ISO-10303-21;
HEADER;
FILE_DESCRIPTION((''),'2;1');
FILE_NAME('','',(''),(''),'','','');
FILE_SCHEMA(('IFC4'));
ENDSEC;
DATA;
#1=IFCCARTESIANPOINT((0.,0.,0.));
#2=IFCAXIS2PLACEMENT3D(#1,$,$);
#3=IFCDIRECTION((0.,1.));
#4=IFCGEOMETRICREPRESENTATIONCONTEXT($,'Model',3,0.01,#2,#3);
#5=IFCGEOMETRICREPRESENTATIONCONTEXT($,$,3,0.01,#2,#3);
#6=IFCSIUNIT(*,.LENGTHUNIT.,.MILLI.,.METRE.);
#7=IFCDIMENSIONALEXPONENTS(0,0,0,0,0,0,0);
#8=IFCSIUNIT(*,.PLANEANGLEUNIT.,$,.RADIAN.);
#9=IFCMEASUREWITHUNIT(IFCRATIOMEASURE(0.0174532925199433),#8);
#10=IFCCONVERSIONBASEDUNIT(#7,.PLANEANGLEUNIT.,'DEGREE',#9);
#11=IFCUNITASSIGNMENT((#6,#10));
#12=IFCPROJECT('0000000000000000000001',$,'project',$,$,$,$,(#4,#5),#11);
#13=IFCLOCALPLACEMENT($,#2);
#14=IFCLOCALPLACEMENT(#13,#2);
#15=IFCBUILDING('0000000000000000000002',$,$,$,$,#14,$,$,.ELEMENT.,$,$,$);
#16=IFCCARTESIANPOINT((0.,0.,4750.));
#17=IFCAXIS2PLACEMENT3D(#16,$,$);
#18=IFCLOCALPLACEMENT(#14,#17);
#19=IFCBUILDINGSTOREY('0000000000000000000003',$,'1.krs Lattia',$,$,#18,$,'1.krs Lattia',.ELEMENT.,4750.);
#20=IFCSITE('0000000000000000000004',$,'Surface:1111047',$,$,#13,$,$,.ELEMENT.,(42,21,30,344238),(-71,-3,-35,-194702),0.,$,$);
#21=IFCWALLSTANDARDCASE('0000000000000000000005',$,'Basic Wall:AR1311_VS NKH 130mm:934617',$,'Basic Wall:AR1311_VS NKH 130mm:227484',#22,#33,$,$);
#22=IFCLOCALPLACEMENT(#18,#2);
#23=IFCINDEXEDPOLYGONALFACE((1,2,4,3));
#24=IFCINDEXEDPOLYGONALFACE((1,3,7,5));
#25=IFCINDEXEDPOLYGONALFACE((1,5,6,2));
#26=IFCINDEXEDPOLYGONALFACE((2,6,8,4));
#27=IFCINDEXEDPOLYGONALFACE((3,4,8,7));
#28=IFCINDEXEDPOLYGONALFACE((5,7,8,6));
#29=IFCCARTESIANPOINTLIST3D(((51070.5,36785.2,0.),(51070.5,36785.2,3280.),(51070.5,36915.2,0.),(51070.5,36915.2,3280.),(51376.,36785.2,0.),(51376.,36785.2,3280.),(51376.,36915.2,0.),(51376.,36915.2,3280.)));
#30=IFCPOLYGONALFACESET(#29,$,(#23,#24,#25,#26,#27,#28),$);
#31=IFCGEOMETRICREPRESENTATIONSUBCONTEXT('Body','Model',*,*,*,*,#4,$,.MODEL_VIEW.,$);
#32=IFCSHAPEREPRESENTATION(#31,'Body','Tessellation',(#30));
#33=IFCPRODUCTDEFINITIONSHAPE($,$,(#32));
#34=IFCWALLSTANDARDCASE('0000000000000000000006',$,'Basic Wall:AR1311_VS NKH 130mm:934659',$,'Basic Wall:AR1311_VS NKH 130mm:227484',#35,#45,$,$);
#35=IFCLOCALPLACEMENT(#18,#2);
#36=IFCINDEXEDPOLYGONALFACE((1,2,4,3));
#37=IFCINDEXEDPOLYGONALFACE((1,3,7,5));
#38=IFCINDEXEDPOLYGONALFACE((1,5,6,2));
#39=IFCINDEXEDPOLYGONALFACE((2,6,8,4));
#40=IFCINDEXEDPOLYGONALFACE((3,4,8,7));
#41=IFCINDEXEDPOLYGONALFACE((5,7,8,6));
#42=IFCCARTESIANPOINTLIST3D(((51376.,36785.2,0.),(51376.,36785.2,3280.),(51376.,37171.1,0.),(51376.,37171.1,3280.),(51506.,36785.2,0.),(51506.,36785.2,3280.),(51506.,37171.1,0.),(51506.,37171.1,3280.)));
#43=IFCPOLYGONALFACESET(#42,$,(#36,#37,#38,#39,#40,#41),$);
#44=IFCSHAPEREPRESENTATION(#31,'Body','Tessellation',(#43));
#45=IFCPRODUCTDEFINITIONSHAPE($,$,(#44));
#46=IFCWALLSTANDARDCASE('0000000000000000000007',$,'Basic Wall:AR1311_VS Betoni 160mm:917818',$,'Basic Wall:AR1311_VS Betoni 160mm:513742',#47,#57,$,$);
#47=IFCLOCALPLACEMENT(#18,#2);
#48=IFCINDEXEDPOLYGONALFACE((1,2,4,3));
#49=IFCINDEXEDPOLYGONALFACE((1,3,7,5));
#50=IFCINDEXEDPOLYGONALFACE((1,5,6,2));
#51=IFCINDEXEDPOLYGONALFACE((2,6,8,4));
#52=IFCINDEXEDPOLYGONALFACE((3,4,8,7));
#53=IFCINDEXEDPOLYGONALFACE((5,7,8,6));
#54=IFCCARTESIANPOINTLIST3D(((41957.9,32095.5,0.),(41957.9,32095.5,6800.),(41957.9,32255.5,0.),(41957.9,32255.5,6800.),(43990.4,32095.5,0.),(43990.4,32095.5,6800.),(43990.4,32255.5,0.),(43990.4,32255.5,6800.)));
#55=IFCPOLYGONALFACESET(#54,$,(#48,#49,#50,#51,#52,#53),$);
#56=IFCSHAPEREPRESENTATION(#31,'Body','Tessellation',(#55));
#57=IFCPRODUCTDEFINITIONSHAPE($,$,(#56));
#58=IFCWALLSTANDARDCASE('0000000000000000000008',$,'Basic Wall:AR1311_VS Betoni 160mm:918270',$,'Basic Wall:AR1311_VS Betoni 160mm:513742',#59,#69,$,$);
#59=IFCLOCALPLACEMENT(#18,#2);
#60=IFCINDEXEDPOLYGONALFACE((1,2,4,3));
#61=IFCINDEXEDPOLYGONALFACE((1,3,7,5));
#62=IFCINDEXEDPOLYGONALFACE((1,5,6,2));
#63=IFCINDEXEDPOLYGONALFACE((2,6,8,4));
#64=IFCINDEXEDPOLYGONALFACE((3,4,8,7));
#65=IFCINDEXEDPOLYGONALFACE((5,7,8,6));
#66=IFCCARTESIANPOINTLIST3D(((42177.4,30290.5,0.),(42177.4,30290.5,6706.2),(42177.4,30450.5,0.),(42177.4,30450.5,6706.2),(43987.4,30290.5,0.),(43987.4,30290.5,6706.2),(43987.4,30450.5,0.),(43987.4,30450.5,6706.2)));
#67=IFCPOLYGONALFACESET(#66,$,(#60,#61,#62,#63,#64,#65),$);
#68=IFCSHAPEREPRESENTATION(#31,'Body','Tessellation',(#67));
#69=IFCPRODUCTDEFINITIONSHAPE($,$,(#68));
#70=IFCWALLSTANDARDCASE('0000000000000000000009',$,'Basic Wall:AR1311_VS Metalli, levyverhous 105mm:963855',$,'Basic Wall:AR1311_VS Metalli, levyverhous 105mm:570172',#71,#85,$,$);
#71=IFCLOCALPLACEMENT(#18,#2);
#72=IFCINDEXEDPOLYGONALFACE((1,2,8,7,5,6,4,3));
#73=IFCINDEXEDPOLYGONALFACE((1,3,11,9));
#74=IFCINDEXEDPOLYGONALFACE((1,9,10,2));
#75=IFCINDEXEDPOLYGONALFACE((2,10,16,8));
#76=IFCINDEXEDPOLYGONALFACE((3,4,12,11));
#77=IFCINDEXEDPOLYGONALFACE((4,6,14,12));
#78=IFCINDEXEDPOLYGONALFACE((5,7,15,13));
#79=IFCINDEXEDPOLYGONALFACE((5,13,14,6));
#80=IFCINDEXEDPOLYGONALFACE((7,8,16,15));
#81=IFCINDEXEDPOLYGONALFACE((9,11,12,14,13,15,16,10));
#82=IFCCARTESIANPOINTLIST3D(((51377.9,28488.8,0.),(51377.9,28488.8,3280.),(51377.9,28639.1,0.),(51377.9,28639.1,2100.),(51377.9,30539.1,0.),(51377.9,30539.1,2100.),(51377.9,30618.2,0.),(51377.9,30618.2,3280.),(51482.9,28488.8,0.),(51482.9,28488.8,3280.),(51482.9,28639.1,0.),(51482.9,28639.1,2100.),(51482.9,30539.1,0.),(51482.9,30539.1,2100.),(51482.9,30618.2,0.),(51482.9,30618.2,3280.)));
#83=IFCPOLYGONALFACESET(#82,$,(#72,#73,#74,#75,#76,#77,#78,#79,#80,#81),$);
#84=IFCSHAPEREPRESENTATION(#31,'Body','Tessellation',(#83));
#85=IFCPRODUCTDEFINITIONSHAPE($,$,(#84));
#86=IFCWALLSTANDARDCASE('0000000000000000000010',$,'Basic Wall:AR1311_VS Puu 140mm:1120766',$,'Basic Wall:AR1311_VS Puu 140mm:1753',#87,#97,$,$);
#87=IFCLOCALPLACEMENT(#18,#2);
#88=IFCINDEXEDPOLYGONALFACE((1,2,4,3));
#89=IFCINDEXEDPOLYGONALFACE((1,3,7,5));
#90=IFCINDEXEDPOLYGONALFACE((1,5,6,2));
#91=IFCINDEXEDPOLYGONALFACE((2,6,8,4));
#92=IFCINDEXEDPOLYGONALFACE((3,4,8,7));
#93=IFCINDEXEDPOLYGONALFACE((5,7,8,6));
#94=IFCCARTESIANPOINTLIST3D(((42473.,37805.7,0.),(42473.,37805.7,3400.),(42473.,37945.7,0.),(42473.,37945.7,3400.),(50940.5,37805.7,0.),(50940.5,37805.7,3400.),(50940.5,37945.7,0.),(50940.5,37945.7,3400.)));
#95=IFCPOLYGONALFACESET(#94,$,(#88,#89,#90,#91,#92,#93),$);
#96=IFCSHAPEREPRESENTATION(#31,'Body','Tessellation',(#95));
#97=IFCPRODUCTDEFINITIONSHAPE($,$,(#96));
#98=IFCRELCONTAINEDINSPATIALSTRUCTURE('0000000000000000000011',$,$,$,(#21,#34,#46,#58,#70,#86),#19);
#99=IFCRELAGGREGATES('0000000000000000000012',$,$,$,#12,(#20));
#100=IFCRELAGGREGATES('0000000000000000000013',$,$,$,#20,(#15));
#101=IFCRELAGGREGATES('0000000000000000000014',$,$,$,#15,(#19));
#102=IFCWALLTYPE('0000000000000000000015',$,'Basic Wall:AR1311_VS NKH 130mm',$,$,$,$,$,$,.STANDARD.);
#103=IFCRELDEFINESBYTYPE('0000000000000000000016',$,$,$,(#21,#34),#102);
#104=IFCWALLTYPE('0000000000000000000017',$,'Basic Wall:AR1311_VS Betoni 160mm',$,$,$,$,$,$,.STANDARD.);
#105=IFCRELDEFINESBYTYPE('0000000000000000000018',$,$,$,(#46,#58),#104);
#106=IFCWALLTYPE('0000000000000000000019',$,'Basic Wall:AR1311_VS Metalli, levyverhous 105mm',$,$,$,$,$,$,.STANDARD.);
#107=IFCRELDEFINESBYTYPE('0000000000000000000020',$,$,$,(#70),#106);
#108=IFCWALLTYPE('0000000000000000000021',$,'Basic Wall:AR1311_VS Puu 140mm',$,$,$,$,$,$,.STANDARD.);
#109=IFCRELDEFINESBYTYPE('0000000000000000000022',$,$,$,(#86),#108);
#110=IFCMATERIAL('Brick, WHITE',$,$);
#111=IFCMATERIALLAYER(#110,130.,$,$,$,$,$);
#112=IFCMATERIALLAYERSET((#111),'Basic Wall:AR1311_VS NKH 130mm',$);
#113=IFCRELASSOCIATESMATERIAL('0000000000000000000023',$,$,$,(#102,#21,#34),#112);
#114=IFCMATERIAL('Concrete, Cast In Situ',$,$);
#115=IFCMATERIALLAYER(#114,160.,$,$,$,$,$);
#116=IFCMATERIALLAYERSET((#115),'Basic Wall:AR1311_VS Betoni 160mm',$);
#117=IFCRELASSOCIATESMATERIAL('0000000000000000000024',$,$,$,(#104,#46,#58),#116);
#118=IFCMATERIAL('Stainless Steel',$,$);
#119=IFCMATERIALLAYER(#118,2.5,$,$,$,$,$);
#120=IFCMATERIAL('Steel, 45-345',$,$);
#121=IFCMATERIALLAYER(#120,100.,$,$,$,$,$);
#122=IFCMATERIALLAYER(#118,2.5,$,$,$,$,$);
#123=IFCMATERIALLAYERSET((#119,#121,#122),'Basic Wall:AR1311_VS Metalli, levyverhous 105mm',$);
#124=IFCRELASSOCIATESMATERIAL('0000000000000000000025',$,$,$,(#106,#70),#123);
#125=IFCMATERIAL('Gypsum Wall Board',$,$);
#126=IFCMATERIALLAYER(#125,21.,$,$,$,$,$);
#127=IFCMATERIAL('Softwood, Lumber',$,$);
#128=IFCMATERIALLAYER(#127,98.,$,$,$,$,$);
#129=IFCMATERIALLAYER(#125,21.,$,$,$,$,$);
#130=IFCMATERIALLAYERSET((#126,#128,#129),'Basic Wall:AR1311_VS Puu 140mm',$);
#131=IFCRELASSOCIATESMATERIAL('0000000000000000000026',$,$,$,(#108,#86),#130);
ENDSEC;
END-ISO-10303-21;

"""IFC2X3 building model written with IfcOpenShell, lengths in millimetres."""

from ifc_helpers import new_model, entity, si_unit, converted_unit, direction, frame, frame_2d, origin, place, context, subcontext, project, spatial, polyline, rectangle, extrude, clip, bounded_halfspace, material, layer, layer_set, layer_usage, type_object, element, save


model = new_model("IFC2X3")

# Units and contexts
model_context = context("Model", 3, precision=0.01, world=origin(), true_north=direction((0.0, 1.0)))
context_of_model = context(None, 3, precision=0.01, world=origin(), true_north=direction((0.0, 1.0)))
body_context = subcontext(model_context, "Body", "Model", "MODEL_VIEW")
ifc_project = project(units=[si_unit("LENGTHUNIT", "METRE", prefix="MILLI"), converted_unit("PLANEANGLEUNIT", "DEGREE", entity("IfcRatioMeasure", 0.0174532925199433), si_unit("PLANEANGLEUNIT", "RADIAN"), dimensions=[0, 0, 0, 0, 0, 0, 0])], contexts=[model_context, context_of_model])

# Site, building, storey
site_placement = place(None, origin())
site = spatial("IfcSite", under=ifc_project, at=site_placement, Name="Surface:1111047", CompositionType="ELEMENT", RefLatitude=(42, 21, 30, 344238), RefLongitude=(-71, -3, -35, -194702), RefElevation=0.0)
building_placement = place(site_placement, origin())
building = spatial("IfcBuilding", under=site, at=building_placement, CompositionType="ELEMENT")
storey_placement = place(building_placement, frame((0.0, 0.0, 4750.0)))
storey = spatial("IfcBuildingStorey", under=building, at=storey_placement, Name="1.krs Lattia", LongName="1.krs Lattia", CompositionType="ELEMENT", Elevation=4750.0)

# Walls
ifc_material_1 = material(Name="Brick, WHITE")
ifc_layer_1 = layer(ifc_material_1, 130.0)
ifc_layer_set_1 = layer_set([ifc_layer_1], Name="Basic Wall:AR1311_VS NKH 130mm")
wall_type_1 = type_object("IfcWallType", Name="Basic Wall:AR1311_VS NKH 130mm", PredefinedType="STANDARD", material=ifc_layer_set_1)
ifc_layer_usage_1 = layer_usage(ifc_layer_set_1, "AXIS2", "NEGATIVE", 65.0)
wall_1_placement = place(storey_placement, frame((51070.5, 36850.2, 0.0)))
element("IfcWallStandardCase", 1, at=wall_1_placement, inside=storey, type_object=wall_type_1, material=ifc_layer_usage_1, Name="Basic Wall:AR1311_VS NKH 130mm:934617", ObjectType="Basic Wall:AR1311_VS NKH 130mm:227484", context=body_context, shape_type="Clipping", body=[
    clip(extrude(rectangle(XDim=305.5, YDim=130.0, at=frame_2d((152.8, 0.0), x_axis=(-1.0, 0.0))), origin(), (0.0, 0.0, 1.0), 3280.0), bounded_halfspace(frame((0.0, -65.0, 3280.0), z_axis=(0.0, 0.0, -1.0), x_axis=(-1.0, 0.0, 0.0)), True, frame((0.0, -65.0, 3280.0)), polyline([(0.0, 0.0), (305.5, 0.0), (305.5, 130.0), (0.0, 130.0), (0.0, 0.0)]))),
])
ifc_layer_usage_2 = layer_usage(ifc_layer_set_1, "AXIS2", "NEGATIVE", 65.0)
wall_2_placement = place(storey_placement, frame((51441.0, 36785.2, 0.0), z_axis=(0.0, 0.0, 1.0), x_axis=(0.0, 1.0, 0.0)))
element("IfcWallStandardCase", 2, at=wall_2_placement, inside=storey, type_object=wall_type_1, material=ifc_layer_usage_2, Name="Basic Wall:AR1311_VS NKH 130mm:934659", ObjectType="Basic Wall:AR1311_VS NKH 130mm:227484", context=body_context, shape_type="Clipping", body=[
    clip(extrude(rectangle(XDim=385.9, YDim=130.0, at=frame_2d((193.0, 0.0), x_axis=(-1.0, 0.0))), origin(), (0.0, 0.0, 1.0), 3280.0), bounded_halfspace(frame((0.0, -65.0, 3280.0), z_axis=(0.0, 0.0, -1.0), x_axis=(0.0, 1.0, 0.0)), True, frame((0.0, -65.0, 3280.0)), polyline([(0.0, 0.0), (255.9, 0.0), (385.9, 0.0), (385.9, 130.0), (130.0, 130.0), (0.0, 130.0), (0.0, 0.0)]))),
])
ifc_material_2 = material(Name="Concrete, Cast In Situ")
ifc_layer_2 = layer(ifc_material_2, 160.0)
ifc_layer_set_2 = layer_set([ifc_layer_2], Name="Basic Wall:AR1311_VS Betoni 160mm")
ifc_layer_usage_3 = layer_usage(ifc_layer_set_2, "AXIS2", "NEGATIVE", 80.0)
wall_type_2 = type_object("IfcWallType", Name="Basic Wall:AR1311_VS Betoni 160mm", PredefinedType="STANDARD", material=ifc_layer_set_2)
wall_3_placement = place(storey_placement, frame((43990.4, 32175.5, 0.0), z_axis=(0.0, 0.0, 1.0), x_axis=(-1.0, 0.0, 0.0)))
element("IfcWallStandardCase", 3, at=wall_3_placement, inside=storey, type_object=wall_type_2, material=ifc_layer_usage_3, Name="Basic Wall:AR1311_VS Betoni 160mm:917818", ObjectType="Basic Wall:AR1311_VS Betoni 160mm:513742", context=body_context, shape_type="SweptSolid", body=[
    extrude(rectangle(XDim=2032.5, YDim=160.0, at=frame_2d((1016.2, 0.0), x_axis=(-1.0, 0.0))), origin(), (0.0, 0.0, 1.0), 6800.0),
])
ifc_layer_usage_4 = layer_usage(ifc_layer_set_2, "AXIS2", "NEGATIVE", 80.0)
wall_4_placement = place(storey_placement, frame((42177.4, 30370.5, 0.0)))
element("IfcWallStandardCase", 4, at=wall_4_placement, inside=storey, type_object=wall_type_2, material=ifc_layer_usage_4, Name="Basic Wall:AR1311_VS Betoni 160mm:918270", ObjectType="Basic Wall:AR1311_VS Betoni 160mm:513742", context=body_context, shape_type="SweptSolid", body=[
    extrude(rectangle(XDim=1810.0, YDim=160.0, at=frame_2d((905.0, 0.0), x_axis=(-1.0, 0.0))), origin(), (0.0, 0.0, 1.0), 6706.2),
])

# Wall, opening
ifc_material_3 = material(Name="Stainless Steel")
ifc_layer_3 = layer(ifc_material_3, 2.5)
ifc_material_4 = material(Name="Steel, 45-345")
ifc_layer_4 = layer(ifc_material_4, 100.0)
ifc_layer_5 = layer(ifc_material_3, 2.5)
ifc_layer_set_3 = layer_set([ifc_layer_3, ifc_layer_4, ifc_layer_5], Name="Basic Wall:AR1311_VS Metalli, levyverhous 105mm")
ifc_layer_usage_5 = layer_usage(ifc_layer_set_3, "AXIS2", "NEGATIVE", 52.5)
wall_type_3 = type_object("IfcWallType", Name="Basic Wall:AR1311_VS Metalli, levyverhous 105mm", PredefinedType="STANDARD", material=ifc_layer_set_3)
wall_5_placement = place(storey_placement, frame((51430.4, 30618.2, 0.0), z_axis=(0.0, 0.0, 1.0), x_axis=(0.0, -1.0, 0.0)))
wall_5 = element("IfcWallStandardCase", 5, at=wall_5_placement, inside=storey, type_object=wall_type_3, material=ifc_layer_usage_5, Name="Basic Wall:AR1311_VS Metalli, levyverhous 105mm:963855", ObjectType="Basic Wall:AR1311_VS Metalli, levyverhous 105mm:570172", context=body_context, shape_type="Clipping", body=[
    clip(extrude(rectangle(XDim=2129.4, YDim=105.0, at=frame_2d((1064.7, 0.0), x_axis=(-1.0, 0.0))), origin(), (0.0, 0.0, 1.0), 3280.0), bounded_halfspace(frame((0.0, -52.5, 3280.0), z_axis=(0.0, 0.0, -1.0), x_axis=(0.0, -1.0, 0.0)), True, frame((0.0, -52.5, 3280.0)), polyline([(0.0, 0.0), (2129.4, 0.0), (2129.4, 105.0), (0.0, 105.0), (0.0, 0.0)]))),
])
opening_placement = place(wall_5_placement, frame((1979.1, 52.5, 0.0)))
element("IfcOpeningElement", 6, at=opening_placement, cuts=wall_5, ObjectType="Opening", context=body_context, shape_type="SweptSolid", body=[
    extrude(rectangle(XDim=2100.0, YDim=1900.0, at=frame_2d((1050.0, 950.0), x_axis=(1.0, 0.0))), frame((0.0, 0.0, 0.0), z_axis=(0.0, -1.0, 0.0), x_axis=(0.0, 0.0, 1.0)), (0.0, 0.0, 1.0), 105.0),
])

# Wall
ifc_material_5 = material(Name="Gypsum Wall Board")
ifc_layer_6 = layer(ifc_material_5, 21.0)
ifc_material_6 = material(Name="Softwood, Lumber")
ifc_layer_7 = layer(ifc_material_6, 98.0)
ifc_layer_8 = layer(ifc_material_5, 21.0)
ifc_layer_set_4 = layer_set([ifc_layer_6, ifc_layer_7, ifc_layer_8], Name="Basic Wall:AR1311_VS Puu 140mm")
ifc_layer_usage_6 = layer_usage(ifc_layer_set_4, "AXIS2", "NEGATIVE", 70.0)
wall_type_4 = type_object("IfcWallType", Name="Basic Wall:AR1311_VS Puu 140mm", PredefinedType="STANDARD", material=ifc_layer_set_4)
wall_6_placement = place(storey_placement, frame((50940.5, 37875.7, 0.0), z_axis=(0.0, 0.0, 1.0), x_axis=(-1.0, 0.0, 0.0)))
element("IfcWallStandardCase", 7, at=wall_6_placement, inside=storey, type_object=wall_type_4, material=ifc_layer_usage_6, Name="Basic Wall:AR1311_VS Puu 140mm:1120766", ObjectType="Basic Wall:AR1311_VS Puu 140mm:1753", context=body_context, shape_type="SweptSolid", body=[
    extrude(rectangle(XDim=8467.5, YDim=140.0, at=frame_2d((4233.7, 0.0), x_axis=(-1.0, 0.0))), origin(), (0.0, 0.0, 1.0), 3400.0),
])

save(model, "model.ifc")
